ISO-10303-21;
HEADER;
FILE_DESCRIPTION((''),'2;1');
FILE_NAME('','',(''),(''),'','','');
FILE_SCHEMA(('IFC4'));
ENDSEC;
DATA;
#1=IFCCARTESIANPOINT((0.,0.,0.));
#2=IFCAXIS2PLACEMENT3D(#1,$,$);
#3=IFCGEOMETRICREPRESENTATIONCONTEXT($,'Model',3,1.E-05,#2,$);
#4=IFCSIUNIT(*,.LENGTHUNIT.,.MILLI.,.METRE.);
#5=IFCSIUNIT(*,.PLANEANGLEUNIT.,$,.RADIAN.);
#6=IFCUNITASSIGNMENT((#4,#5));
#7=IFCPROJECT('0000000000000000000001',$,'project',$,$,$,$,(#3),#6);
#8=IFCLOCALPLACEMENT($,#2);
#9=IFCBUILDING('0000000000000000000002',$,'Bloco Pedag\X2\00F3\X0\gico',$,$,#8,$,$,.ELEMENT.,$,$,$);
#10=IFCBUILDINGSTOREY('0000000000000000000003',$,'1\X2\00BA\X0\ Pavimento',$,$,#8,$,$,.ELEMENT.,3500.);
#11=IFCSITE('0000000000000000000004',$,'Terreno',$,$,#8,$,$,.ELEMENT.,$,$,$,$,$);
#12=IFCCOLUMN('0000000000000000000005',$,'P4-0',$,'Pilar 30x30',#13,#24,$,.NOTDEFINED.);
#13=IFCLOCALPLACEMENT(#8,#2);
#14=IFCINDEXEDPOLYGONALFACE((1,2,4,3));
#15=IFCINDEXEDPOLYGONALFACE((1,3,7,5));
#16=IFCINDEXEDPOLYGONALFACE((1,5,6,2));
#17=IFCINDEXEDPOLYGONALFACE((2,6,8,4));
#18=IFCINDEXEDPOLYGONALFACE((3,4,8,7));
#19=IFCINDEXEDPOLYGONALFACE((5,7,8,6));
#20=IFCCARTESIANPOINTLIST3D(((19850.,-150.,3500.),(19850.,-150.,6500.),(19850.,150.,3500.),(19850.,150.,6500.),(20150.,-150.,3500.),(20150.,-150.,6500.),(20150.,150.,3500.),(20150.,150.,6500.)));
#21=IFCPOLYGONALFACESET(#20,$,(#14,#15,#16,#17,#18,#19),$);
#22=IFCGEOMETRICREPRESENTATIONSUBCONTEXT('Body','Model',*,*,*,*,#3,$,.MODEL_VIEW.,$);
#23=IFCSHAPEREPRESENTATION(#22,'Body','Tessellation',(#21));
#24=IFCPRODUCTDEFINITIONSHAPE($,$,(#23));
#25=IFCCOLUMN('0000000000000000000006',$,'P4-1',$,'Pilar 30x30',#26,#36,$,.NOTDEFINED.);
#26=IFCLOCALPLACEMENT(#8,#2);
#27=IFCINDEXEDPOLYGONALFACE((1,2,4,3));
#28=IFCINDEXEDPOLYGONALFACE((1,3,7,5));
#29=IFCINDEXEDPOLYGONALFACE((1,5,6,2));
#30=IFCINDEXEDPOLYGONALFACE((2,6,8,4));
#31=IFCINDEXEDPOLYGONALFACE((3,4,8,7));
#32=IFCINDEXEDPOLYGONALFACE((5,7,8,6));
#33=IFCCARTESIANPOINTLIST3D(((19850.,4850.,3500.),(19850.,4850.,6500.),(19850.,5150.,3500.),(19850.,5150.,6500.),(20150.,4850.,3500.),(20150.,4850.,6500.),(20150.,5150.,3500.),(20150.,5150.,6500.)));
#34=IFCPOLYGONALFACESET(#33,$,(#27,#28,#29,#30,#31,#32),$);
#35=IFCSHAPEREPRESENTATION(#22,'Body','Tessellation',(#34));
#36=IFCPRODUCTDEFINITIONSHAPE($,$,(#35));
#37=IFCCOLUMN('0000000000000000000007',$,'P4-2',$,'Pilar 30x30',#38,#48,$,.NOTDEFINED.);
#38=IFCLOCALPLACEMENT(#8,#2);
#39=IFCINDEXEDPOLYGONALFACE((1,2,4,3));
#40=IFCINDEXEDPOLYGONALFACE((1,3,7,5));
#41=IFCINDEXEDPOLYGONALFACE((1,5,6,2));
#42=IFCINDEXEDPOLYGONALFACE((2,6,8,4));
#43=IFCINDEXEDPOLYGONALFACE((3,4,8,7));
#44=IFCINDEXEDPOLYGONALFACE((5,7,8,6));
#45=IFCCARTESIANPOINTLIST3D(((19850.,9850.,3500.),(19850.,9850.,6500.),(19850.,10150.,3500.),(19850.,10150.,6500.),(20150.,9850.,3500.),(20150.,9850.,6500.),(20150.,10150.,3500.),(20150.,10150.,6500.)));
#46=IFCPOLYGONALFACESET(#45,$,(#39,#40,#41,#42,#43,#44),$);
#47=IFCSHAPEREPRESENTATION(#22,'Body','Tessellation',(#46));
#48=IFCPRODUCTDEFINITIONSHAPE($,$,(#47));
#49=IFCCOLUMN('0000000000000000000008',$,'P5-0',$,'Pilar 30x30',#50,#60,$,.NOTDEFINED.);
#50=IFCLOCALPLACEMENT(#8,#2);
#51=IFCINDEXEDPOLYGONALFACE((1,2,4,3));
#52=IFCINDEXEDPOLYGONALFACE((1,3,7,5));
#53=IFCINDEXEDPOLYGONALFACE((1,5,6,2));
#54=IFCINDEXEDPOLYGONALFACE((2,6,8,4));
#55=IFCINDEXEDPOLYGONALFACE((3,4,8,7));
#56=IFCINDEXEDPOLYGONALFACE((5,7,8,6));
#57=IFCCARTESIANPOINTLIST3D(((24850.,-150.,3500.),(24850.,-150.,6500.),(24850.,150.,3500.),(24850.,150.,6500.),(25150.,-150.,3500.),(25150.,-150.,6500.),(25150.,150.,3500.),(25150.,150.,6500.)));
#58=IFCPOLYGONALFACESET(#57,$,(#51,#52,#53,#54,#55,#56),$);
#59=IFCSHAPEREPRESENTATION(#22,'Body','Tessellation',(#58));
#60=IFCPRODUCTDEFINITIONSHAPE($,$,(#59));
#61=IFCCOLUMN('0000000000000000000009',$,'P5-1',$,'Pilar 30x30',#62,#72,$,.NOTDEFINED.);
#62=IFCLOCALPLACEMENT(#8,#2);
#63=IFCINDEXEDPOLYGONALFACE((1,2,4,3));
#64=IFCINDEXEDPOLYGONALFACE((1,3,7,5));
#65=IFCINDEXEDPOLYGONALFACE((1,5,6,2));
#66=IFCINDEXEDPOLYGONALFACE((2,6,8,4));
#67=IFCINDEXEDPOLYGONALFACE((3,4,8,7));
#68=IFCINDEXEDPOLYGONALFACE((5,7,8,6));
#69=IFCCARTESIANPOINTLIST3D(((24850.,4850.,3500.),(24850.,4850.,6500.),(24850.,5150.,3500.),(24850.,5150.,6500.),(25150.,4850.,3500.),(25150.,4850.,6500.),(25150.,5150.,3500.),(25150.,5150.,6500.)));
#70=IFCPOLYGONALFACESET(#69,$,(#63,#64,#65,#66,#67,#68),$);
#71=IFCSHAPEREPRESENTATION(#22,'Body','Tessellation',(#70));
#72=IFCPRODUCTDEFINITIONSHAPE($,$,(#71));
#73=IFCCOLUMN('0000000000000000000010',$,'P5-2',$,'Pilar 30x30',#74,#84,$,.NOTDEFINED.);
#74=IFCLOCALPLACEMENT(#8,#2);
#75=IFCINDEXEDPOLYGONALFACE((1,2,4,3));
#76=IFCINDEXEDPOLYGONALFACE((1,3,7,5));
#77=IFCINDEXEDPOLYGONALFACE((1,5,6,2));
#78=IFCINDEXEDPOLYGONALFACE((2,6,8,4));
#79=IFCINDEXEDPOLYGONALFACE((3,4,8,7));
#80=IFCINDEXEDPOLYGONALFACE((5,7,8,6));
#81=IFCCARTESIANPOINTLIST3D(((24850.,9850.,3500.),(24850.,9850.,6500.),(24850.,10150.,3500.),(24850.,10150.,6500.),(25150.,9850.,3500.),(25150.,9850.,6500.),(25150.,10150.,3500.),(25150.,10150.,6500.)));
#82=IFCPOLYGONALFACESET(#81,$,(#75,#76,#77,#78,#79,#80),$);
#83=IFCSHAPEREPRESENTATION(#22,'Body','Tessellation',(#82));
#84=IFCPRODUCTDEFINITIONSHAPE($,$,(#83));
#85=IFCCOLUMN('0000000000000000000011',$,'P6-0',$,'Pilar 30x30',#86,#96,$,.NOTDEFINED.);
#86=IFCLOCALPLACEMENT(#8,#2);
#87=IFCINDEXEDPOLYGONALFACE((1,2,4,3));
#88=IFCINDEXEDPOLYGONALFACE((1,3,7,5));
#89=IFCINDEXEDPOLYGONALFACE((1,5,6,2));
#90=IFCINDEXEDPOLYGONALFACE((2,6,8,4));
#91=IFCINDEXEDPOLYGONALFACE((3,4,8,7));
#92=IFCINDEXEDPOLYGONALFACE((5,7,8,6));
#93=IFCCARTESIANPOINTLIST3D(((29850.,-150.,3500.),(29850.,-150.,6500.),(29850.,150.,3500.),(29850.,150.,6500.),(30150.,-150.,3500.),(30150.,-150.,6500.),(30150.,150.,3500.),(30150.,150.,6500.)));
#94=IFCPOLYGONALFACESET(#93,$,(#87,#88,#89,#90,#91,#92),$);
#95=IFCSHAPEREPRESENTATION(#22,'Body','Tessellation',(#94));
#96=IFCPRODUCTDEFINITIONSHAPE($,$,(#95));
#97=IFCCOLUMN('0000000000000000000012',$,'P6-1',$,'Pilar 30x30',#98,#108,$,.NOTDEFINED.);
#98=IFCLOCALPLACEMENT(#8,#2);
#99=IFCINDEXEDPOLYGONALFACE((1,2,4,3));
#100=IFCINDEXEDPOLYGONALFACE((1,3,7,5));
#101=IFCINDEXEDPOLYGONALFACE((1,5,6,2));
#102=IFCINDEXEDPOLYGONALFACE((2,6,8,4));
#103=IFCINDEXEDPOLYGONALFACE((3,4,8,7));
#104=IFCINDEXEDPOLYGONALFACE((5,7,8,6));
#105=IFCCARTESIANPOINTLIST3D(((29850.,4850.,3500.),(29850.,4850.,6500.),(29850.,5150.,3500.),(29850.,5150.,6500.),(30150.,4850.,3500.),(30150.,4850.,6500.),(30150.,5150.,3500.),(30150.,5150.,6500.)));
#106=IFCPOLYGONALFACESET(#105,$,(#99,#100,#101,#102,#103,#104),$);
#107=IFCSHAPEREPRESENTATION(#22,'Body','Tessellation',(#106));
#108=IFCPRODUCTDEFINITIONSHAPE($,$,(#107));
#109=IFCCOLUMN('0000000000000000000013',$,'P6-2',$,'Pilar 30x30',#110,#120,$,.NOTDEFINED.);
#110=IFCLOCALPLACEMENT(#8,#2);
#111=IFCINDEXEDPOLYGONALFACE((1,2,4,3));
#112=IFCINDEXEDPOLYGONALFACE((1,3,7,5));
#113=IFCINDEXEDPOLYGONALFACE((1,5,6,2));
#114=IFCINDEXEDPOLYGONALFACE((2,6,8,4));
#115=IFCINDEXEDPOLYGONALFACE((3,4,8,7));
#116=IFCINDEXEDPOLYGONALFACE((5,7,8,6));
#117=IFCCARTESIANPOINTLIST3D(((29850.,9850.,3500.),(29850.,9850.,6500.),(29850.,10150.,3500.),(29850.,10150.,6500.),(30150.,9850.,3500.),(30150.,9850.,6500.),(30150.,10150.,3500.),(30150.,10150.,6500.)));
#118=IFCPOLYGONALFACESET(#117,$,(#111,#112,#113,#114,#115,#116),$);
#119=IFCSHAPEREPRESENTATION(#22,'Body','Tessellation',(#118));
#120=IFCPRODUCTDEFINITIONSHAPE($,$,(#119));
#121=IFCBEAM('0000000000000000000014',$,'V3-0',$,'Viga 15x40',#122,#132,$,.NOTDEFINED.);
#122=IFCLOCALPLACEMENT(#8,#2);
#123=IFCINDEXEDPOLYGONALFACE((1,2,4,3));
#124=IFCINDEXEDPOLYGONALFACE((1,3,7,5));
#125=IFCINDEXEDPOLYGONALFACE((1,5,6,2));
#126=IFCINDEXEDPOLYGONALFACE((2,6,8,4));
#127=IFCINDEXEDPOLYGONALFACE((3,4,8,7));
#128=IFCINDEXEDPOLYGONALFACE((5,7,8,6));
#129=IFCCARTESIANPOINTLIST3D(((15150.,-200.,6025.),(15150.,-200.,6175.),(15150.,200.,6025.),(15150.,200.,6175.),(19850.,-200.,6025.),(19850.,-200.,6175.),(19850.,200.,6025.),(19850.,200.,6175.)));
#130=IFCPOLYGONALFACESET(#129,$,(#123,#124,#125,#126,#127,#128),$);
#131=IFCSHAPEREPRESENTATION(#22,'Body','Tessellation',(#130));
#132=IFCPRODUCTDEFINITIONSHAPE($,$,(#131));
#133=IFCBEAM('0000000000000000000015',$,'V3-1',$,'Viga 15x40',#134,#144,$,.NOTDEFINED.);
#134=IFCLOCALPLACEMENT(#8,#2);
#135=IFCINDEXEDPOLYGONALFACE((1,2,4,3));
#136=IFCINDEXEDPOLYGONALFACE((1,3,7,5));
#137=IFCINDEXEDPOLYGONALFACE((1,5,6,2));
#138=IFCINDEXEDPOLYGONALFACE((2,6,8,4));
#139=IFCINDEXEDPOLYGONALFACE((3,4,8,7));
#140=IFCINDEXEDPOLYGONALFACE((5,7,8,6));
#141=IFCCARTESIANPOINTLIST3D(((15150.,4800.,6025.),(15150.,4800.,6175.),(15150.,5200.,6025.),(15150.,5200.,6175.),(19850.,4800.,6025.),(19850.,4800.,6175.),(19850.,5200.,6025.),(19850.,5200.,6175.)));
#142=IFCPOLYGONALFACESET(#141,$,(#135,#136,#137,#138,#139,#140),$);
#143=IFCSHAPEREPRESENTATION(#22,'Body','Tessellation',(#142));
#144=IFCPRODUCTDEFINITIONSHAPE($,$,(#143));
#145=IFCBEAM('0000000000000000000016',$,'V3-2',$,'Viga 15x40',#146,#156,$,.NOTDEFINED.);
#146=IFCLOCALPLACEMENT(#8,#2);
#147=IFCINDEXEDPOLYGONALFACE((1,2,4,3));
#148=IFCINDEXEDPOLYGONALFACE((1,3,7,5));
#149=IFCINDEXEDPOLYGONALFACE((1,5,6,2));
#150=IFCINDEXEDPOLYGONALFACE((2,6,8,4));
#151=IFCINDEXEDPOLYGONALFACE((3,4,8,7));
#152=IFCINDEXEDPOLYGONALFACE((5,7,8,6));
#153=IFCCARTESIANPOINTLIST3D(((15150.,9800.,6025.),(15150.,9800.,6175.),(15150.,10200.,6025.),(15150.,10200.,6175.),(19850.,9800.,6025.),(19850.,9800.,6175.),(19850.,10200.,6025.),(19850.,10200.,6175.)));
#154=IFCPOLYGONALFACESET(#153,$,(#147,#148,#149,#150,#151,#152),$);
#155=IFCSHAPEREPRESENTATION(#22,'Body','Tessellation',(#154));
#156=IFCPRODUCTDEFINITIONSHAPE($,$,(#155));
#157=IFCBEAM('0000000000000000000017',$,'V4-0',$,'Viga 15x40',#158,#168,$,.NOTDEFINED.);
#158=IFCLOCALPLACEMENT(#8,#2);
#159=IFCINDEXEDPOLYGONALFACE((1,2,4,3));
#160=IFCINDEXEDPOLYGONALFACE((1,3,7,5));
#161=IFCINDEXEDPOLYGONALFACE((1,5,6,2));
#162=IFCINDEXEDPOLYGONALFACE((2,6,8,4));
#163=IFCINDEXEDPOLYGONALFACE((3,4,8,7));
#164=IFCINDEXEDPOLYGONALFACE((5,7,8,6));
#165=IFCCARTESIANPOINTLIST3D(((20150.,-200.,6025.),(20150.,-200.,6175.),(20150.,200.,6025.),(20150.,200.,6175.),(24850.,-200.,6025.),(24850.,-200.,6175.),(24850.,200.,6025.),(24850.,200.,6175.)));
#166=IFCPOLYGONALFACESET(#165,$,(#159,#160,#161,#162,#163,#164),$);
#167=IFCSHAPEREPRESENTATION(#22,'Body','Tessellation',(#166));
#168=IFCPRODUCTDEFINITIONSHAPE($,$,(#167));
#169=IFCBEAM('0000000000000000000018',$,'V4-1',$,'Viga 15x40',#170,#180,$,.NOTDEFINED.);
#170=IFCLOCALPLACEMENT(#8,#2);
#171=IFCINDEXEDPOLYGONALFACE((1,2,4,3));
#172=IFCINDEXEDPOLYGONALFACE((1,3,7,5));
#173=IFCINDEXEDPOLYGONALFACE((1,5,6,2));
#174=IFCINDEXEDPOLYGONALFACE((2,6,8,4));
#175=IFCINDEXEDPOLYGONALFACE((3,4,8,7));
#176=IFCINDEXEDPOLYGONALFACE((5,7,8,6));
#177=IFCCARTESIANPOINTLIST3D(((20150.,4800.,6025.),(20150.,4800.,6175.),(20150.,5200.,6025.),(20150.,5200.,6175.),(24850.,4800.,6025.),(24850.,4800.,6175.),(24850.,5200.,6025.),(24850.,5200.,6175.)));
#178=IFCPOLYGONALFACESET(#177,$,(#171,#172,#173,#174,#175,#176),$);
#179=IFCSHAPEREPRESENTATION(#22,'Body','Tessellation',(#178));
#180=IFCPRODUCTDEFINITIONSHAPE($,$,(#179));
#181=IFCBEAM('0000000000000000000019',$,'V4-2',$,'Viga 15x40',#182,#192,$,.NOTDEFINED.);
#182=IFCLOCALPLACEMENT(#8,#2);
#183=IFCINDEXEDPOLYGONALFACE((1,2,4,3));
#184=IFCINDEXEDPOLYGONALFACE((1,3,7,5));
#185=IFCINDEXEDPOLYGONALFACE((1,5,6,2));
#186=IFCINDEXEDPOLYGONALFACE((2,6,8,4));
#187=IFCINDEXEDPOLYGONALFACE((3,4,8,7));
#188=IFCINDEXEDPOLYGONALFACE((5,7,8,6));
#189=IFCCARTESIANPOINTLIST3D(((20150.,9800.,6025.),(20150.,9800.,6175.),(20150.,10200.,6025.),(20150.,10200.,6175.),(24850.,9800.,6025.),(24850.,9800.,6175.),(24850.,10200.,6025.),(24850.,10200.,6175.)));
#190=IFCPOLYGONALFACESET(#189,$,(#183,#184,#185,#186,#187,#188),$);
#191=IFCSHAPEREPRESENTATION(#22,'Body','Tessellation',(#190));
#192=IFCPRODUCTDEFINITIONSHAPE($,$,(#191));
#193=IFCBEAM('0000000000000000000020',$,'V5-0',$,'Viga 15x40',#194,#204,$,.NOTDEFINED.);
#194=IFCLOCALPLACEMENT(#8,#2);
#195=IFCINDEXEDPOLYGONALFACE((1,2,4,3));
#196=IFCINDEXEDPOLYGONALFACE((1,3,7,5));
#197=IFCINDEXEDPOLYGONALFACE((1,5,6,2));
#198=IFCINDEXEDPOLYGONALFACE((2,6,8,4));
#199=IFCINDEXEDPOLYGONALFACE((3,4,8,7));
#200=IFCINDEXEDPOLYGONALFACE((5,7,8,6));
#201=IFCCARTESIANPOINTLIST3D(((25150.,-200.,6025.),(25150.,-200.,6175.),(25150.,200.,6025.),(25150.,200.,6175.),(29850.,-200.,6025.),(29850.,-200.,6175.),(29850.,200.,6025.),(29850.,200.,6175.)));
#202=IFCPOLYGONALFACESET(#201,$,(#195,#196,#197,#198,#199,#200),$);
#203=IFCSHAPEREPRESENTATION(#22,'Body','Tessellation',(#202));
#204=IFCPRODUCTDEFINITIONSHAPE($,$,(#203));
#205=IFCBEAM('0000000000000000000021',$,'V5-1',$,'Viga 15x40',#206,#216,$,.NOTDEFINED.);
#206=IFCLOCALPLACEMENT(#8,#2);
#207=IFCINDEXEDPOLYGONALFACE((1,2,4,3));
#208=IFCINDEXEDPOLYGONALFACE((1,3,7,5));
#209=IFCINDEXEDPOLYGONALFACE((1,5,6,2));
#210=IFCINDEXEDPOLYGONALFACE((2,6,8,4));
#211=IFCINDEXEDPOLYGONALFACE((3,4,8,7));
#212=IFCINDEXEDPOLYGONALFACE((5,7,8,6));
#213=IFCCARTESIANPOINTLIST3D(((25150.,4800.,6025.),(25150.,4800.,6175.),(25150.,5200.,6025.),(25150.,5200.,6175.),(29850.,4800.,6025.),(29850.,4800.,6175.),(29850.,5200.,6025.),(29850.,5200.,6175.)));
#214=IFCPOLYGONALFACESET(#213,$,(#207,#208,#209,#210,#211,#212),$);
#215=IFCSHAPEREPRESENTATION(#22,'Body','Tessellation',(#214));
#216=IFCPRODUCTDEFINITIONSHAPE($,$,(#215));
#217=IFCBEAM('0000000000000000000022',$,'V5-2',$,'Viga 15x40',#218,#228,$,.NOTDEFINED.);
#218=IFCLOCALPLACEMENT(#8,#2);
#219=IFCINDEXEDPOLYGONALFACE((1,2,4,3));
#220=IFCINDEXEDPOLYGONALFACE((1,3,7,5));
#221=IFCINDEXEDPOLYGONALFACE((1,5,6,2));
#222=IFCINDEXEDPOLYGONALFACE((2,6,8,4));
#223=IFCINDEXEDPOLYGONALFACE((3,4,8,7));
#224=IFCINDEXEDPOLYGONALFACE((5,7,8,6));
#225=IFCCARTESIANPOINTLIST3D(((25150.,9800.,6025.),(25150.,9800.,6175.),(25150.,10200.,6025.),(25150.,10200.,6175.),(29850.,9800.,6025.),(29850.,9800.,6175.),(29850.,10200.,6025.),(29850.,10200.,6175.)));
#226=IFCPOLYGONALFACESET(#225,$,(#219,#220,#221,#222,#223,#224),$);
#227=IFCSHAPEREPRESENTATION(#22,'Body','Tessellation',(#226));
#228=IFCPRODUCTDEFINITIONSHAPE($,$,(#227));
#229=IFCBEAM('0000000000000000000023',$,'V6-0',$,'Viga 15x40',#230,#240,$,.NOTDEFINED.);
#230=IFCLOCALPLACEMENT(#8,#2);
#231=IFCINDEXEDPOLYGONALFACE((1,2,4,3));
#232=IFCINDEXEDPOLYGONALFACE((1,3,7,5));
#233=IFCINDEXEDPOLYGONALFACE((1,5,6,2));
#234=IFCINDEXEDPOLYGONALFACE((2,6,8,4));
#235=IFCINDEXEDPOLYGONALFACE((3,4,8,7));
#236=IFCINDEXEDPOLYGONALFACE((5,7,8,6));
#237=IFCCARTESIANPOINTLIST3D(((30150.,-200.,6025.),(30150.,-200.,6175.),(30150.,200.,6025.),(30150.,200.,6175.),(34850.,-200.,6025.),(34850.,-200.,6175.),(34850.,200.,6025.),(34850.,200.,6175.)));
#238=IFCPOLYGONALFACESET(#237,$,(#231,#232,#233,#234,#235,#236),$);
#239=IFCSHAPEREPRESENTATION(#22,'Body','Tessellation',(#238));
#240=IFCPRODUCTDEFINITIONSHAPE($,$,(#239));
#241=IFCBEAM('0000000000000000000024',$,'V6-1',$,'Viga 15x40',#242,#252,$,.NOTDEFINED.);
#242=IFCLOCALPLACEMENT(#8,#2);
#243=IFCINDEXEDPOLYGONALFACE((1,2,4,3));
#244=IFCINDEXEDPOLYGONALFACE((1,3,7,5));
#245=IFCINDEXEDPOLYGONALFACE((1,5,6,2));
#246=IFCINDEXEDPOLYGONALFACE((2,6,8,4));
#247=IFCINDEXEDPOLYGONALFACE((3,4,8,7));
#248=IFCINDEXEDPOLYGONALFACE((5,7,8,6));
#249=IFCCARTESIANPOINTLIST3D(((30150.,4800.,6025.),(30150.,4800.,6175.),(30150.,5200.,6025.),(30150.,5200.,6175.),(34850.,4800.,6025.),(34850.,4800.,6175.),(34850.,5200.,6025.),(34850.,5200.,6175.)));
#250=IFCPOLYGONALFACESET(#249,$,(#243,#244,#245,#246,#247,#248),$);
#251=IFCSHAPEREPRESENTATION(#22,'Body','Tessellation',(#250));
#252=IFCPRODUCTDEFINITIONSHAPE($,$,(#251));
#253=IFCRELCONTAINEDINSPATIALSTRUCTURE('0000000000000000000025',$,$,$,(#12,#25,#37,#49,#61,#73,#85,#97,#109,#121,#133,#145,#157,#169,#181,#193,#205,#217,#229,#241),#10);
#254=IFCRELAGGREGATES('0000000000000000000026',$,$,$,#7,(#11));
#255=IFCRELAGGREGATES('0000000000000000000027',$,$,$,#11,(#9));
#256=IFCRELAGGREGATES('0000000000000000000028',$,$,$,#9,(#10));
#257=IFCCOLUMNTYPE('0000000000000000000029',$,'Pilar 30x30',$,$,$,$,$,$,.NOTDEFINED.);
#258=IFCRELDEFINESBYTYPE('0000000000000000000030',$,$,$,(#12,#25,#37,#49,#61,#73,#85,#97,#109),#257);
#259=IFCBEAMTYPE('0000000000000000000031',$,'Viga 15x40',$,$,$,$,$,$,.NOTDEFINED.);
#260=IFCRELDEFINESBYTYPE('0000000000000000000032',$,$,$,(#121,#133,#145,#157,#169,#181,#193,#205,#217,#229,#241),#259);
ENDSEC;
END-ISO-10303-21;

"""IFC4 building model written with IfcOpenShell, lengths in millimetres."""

from ifc_helpers import new_model, si_unit, frame, origin, origin_2d, place, context, subcontext, project, spatial, rectangle, extrude, type_object, element, save


model = new_model("IFC4")

# Units and contexts
model_context = context("Model", 3, precision=1e-05, world=origin())
body_context = subcontext(model_context, "Body", "Model", "MODEL_VIEW")
ifc_project = project(units=[si_unit("LENGTHUNIT", "METRE", prefix="MILLI"), si_unit("PLANEANGLEUNIT", "RADIAN")], contexts=[model_context])

# Site, building, storey
placement = place(None, origin())
site = spatial("IfcSite", under=ifc_project, at=placement, Name="Terreno", CompositionType="ELEMENT")
building = spatial("IfcBuilding", under=site, at=placement, Name="Bloco Pedagógico", CompositionType="ELEMENT")
storey = spatial("IfcBuildingStorey", under=building, at=placement, Name="1º Pavimento", CompositionType="ELEMENT", Elevation=3500.0)

# Columns
column_type = type_object("IfcColumnType", Name="Pilar 30x30", PredefinedType="NOTDEFINED")
for number, where, z_axis, x_axis, name in (
    (1, (20000.0, 0.0, 3500.0), (0.0, 0.0, 1.0), (1.0, 0.0, 0.0), "P4-0"),
    (2, (20000.0, 5000.0, 3500.0), (0.0, 0.0, 1.0), (1.0, 0.0, 0.0), "P4-1"),
    (3, (20000.0, 10000.0, 3500.0), (0.0, 0.0, 1.0), (1.0, 0.0, 0.0), "P4-2"),
    (4, (25000.0, 0.0, 3500.0), (0.0, 0.0, 1.0), (1.0, 0.0, 0.0), "P5-0"),
    (5, (25000.0, 5000.0, 3500.0), (0.0, 0.0, 1.0), (1.0, 0.0, 0.0), "P5-1"),
    (6, (25000.0, 10000.0, 3500.0), (0.0, 0.0, 1.0), (1.0, 0.0, 0.0), "P5-2"),
    (7, (30000.0, 0.0, 3500.0), (0.0, 0.0, 1.0), (1.0, 0.0, 0.0), "P6-0"),
    (8, (30000.0, 5000.0, 3500.0), (0.0, 0.0, 1.0), (1.0, 0.0, 0.0), "P6-1"),
    (9, (30000.0, 10000.0, 3500.0), (0.0, 0.0, 1.0), (1.0, 0.0, 0.0), "P6-2"),
):
    element("IfcColumn", number, at=place(None, frame(where, z_axis=z_axis, x_axis=x_axis)), inside=storey, type_object=column_type, Name=name, ObjectType="Pilar 30x30", PredefinedType="NOTDEFINED", context=body_context, shape_type="SweptSolid", body=[
        extrude(rectangle(XDim=300.0, YDim=300.0, at=origin_2d()), None, (0.0, 0.0, 1.0), 3000.0),
    ])

# Beams
beam_type = type_object("IfcBeamType", Name="Viga 15x40", PredefinedType="NOTDEFINED")
for number, where, z_axis, x_axis, name in (
    (10, (15150.0, 0.0, 6100.0), (1.0, 0.0, 0.0), (0.0, 1.0, 0.0), "V3-0"),
    (11, (15150.0, 5000.0, 6100.0), (1.0, 0.0, 0.0), (0.0, 1.0, 0.0), "V3-1"),
    (12, (15150.0, 10000.0, 6100.0), (1.0, 0.0, 0.0), (0.0, 1.0, 0.0), "V3-2"),
    (13, (20150.0, 0.0, 6100.0), (1.0, 0.0, 0.0), (0.0, 1.0, 0.0), "V4-0"),
    (14, (20150.0, 5000.0, 6100.0), (1.0, 0.0, 0.0), (0.0, 1.0, 0.0), "V4-1"),
    (15, (20150.0, 10000.0, 6100.0), (1.0, 0.0, 0.0), (0.0, 1.0, 0.0), "V4-2"),
    (16, (25150.0, 0.0, 6100.0), (1.0, 0.0, 0.0), (0.0, 1.0, 0.0), "V5-0"),
    (17, (25150.0, 5000.0, 6100.0), (1.0, 0.0, 0.0), (0.0, 1.0, 0.0), "V5-1"),
    (18, (25150.0, 10000.0, 6100.0), (1.0, 0.0, 0.0), (0.0, 1.0, 0.0), "V5-2"),
    (19, (30150.0, 0.0, 6100.0), (1.0, 0.0, 0.0), (0.0, 1.0, 0.0), "V6-0"),
    (20, (30150.0, 5000.0, 6100.0), (1.0, 0.0, 0.0), (0.0, 1.0, 0.0), "V6-1"),
):
    element("IfcBeam", number, at=place(None, frame(where, z_axis=z_axis, x_axis=x_axis)), inside=storey, type_object=beam_type, Name=name, ObjectType="Viga 15x40", PredefinedType="NOTDEFINED", context=body_context, shape_type="SweptSolid", body=[
        extrude(rectangle(XDim=400.0, YDim=150.0, at=origin_2d()), None, (0.0, 0.0, 1.0), 4700.0),
    ])

save(model, "model.ifc")
